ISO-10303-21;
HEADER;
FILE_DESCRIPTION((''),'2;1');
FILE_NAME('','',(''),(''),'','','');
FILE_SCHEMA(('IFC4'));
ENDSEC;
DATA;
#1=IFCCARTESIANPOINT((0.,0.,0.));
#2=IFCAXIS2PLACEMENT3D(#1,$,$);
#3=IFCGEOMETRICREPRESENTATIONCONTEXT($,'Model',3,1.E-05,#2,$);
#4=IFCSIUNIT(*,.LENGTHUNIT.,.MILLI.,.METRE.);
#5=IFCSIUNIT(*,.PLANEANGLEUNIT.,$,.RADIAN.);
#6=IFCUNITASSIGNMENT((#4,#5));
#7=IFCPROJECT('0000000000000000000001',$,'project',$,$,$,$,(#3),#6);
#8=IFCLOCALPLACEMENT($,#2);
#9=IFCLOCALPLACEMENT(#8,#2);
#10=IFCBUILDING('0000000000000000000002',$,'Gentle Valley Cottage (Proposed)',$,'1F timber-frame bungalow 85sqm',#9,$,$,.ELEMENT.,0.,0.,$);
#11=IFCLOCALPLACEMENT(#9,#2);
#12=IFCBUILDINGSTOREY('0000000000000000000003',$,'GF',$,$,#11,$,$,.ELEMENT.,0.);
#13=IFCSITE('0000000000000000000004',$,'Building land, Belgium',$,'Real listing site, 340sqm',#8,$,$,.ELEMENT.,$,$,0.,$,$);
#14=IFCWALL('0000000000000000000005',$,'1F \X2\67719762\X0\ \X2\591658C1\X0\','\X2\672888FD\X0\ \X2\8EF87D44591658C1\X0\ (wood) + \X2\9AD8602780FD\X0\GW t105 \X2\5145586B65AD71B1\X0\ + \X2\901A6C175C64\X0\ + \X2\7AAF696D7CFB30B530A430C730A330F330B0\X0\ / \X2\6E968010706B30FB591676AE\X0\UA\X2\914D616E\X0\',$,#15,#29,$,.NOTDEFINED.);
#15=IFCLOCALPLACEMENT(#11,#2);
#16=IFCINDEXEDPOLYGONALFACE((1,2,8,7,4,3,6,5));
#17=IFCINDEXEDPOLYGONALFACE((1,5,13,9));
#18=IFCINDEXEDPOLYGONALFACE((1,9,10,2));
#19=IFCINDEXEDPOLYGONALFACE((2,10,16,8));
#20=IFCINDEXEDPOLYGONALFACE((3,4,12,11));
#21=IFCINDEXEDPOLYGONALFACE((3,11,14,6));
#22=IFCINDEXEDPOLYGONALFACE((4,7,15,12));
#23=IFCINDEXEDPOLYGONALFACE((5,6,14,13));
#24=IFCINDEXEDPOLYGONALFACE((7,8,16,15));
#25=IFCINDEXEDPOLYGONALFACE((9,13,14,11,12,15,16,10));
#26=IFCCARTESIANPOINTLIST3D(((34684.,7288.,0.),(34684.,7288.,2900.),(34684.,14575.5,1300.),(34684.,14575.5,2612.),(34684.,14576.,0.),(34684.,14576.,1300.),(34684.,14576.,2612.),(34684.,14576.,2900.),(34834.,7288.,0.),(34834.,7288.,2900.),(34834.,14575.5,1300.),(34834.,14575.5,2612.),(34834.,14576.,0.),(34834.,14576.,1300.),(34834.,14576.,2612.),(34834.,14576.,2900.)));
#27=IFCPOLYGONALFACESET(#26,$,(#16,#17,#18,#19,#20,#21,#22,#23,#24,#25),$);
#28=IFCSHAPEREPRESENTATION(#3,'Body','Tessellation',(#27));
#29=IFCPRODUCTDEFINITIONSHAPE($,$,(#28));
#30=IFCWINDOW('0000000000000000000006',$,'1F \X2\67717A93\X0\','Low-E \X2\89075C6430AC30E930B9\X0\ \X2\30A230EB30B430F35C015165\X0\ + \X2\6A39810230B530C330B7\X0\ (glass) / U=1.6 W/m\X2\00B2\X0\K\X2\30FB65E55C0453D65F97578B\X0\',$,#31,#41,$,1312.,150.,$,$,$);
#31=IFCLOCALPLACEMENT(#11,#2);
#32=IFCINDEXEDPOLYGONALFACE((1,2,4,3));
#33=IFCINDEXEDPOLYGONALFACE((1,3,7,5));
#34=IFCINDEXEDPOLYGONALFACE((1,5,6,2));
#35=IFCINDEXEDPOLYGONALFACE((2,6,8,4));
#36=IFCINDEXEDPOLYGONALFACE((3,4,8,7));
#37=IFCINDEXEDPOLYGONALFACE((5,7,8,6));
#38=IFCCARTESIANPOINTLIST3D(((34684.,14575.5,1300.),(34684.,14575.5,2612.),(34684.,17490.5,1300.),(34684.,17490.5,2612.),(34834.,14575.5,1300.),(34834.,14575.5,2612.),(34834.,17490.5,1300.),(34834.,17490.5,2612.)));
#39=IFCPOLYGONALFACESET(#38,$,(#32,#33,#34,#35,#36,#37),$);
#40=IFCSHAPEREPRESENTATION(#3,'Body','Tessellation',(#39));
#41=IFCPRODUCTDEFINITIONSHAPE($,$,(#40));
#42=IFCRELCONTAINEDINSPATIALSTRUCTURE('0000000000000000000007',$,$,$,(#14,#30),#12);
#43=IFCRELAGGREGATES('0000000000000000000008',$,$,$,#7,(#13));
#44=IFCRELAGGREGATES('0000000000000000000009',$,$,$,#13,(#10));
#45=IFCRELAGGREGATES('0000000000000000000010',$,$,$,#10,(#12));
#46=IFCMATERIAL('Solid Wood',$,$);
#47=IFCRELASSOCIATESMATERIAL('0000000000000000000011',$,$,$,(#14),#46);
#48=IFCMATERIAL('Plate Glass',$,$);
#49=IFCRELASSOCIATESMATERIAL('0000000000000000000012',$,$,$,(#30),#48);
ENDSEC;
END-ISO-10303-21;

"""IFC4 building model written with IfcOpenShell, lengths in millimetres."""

from ifc_helpers import new_model, si_unit, frame, frame_2d, origin, place, context, project, spatial, rectangle, extrude, material, element, fill, save


model = new_model("IFC4")

# Units and contexts
model_context = context("Model", 3, precision=1e-05, world=origin())
ifc_project = project(units=[si_unit("LENGTHUNIT", "METRE", prefix="MILLI"), si_unit("PLANEANGLEUNIT", "RADIAN")], contexts=[model_context])

# Site, building, storey
site_placement = place(None, origin())
site = spatial("IfcSite", under=ifc_project, at=site_placement, Name="Building land, Belgium", ObjectType="Real listing site, 340sqm", CompositionType="ELEMENT", RefElevation=0.0)
building_placement = place(site_placement, origin())
building = spatial("IfcBuilding", under=site, at=building_placement, Name="Gentle Valley Cottage (Proposed)", ObjectType="1F timber-frame bungalow 85sqm", CompositionType="ELEMENT", ElevationOfRefHeight=0.0, ElevationOfTerrain=0.0)
storey_placement = place(building_placement, origin())
storey = spatial("IfcBuildingStorey", under=building, at=storey_placement, Name="GF", CompositionType="ELEMENT", Elevation=0.0)

# Shared definitions
ifc_material_1 = material(Name="Solid Wood")

# Wall, opening, window
wall_1_placement = place(storey_placement, frame((17342.0, 3644.0, 0.0)))
wall_1 = element("IfcWall", 1, at=wall_1_placement, inside=storey, material=ifc_material_1, Name="1F 東面 外壁", Description="木製 軸組外壁 (wood) + 高性能GW t105 充填断熱 + 通気層 + 窯業系サイディング / 準耐火・外皮UA配慮", PredefinedType="NOTDEFINED", context=model_context, shape_type="SweptSolid", body=[
    extrude(rectangle(XDim=150.0, YDim=7288.0, at=frame_2d((75.0, 3644.0))), frame((17342.0, 3644.0, 0.0)), (0.0, 0.0, 1.0), 2900.0),
])
opening_placement = place(storey_placement, frame((17342.0, 7288.0, 650.0)))
opening = element("IfcOpeningElement", 2, at=opening_placement, cuts=wall_1, PredefinedType="NOTDEFINED", context=model_context, shape_type="SweptSolid", body=[
    extrude(rectangle(XDim=150.0, YDim=2915.0, at=frame_2d((75.0, 1457.0))), frame((17342.0, 7288.0, 650.0)), (0.0, 0.0, 1.0), 1312.0),
])
ifc_material_2 = material(Name="Plate Glass")
window_placement = place(storey_placement, frame((17342.0, 7288.0, 650.0)))
window = element("IfcWindow", 3, at=window_placement, inside=storey, material=ifc_material_2, Name="1F 東窓", Description="Low-E 複層ガラス アルゴン封入 + 樹脂サッシ (glass) / U=1.6 W/m²K・日射取得型", OverallHeight=1312.0, OverallWidth=150.0, context=model_context, shape_type="SweptSolid", body=[
    extrude(rectangle(XDim=150.0, YDim=2915.0, at=frame_2d((75.0, 1457.0))), frame((17342.0, 7288.0, 650.0)), (0.0, 0.0, 1.0), 1312.0),
])
fill(opening, window)

save(model, "model.ifc")
